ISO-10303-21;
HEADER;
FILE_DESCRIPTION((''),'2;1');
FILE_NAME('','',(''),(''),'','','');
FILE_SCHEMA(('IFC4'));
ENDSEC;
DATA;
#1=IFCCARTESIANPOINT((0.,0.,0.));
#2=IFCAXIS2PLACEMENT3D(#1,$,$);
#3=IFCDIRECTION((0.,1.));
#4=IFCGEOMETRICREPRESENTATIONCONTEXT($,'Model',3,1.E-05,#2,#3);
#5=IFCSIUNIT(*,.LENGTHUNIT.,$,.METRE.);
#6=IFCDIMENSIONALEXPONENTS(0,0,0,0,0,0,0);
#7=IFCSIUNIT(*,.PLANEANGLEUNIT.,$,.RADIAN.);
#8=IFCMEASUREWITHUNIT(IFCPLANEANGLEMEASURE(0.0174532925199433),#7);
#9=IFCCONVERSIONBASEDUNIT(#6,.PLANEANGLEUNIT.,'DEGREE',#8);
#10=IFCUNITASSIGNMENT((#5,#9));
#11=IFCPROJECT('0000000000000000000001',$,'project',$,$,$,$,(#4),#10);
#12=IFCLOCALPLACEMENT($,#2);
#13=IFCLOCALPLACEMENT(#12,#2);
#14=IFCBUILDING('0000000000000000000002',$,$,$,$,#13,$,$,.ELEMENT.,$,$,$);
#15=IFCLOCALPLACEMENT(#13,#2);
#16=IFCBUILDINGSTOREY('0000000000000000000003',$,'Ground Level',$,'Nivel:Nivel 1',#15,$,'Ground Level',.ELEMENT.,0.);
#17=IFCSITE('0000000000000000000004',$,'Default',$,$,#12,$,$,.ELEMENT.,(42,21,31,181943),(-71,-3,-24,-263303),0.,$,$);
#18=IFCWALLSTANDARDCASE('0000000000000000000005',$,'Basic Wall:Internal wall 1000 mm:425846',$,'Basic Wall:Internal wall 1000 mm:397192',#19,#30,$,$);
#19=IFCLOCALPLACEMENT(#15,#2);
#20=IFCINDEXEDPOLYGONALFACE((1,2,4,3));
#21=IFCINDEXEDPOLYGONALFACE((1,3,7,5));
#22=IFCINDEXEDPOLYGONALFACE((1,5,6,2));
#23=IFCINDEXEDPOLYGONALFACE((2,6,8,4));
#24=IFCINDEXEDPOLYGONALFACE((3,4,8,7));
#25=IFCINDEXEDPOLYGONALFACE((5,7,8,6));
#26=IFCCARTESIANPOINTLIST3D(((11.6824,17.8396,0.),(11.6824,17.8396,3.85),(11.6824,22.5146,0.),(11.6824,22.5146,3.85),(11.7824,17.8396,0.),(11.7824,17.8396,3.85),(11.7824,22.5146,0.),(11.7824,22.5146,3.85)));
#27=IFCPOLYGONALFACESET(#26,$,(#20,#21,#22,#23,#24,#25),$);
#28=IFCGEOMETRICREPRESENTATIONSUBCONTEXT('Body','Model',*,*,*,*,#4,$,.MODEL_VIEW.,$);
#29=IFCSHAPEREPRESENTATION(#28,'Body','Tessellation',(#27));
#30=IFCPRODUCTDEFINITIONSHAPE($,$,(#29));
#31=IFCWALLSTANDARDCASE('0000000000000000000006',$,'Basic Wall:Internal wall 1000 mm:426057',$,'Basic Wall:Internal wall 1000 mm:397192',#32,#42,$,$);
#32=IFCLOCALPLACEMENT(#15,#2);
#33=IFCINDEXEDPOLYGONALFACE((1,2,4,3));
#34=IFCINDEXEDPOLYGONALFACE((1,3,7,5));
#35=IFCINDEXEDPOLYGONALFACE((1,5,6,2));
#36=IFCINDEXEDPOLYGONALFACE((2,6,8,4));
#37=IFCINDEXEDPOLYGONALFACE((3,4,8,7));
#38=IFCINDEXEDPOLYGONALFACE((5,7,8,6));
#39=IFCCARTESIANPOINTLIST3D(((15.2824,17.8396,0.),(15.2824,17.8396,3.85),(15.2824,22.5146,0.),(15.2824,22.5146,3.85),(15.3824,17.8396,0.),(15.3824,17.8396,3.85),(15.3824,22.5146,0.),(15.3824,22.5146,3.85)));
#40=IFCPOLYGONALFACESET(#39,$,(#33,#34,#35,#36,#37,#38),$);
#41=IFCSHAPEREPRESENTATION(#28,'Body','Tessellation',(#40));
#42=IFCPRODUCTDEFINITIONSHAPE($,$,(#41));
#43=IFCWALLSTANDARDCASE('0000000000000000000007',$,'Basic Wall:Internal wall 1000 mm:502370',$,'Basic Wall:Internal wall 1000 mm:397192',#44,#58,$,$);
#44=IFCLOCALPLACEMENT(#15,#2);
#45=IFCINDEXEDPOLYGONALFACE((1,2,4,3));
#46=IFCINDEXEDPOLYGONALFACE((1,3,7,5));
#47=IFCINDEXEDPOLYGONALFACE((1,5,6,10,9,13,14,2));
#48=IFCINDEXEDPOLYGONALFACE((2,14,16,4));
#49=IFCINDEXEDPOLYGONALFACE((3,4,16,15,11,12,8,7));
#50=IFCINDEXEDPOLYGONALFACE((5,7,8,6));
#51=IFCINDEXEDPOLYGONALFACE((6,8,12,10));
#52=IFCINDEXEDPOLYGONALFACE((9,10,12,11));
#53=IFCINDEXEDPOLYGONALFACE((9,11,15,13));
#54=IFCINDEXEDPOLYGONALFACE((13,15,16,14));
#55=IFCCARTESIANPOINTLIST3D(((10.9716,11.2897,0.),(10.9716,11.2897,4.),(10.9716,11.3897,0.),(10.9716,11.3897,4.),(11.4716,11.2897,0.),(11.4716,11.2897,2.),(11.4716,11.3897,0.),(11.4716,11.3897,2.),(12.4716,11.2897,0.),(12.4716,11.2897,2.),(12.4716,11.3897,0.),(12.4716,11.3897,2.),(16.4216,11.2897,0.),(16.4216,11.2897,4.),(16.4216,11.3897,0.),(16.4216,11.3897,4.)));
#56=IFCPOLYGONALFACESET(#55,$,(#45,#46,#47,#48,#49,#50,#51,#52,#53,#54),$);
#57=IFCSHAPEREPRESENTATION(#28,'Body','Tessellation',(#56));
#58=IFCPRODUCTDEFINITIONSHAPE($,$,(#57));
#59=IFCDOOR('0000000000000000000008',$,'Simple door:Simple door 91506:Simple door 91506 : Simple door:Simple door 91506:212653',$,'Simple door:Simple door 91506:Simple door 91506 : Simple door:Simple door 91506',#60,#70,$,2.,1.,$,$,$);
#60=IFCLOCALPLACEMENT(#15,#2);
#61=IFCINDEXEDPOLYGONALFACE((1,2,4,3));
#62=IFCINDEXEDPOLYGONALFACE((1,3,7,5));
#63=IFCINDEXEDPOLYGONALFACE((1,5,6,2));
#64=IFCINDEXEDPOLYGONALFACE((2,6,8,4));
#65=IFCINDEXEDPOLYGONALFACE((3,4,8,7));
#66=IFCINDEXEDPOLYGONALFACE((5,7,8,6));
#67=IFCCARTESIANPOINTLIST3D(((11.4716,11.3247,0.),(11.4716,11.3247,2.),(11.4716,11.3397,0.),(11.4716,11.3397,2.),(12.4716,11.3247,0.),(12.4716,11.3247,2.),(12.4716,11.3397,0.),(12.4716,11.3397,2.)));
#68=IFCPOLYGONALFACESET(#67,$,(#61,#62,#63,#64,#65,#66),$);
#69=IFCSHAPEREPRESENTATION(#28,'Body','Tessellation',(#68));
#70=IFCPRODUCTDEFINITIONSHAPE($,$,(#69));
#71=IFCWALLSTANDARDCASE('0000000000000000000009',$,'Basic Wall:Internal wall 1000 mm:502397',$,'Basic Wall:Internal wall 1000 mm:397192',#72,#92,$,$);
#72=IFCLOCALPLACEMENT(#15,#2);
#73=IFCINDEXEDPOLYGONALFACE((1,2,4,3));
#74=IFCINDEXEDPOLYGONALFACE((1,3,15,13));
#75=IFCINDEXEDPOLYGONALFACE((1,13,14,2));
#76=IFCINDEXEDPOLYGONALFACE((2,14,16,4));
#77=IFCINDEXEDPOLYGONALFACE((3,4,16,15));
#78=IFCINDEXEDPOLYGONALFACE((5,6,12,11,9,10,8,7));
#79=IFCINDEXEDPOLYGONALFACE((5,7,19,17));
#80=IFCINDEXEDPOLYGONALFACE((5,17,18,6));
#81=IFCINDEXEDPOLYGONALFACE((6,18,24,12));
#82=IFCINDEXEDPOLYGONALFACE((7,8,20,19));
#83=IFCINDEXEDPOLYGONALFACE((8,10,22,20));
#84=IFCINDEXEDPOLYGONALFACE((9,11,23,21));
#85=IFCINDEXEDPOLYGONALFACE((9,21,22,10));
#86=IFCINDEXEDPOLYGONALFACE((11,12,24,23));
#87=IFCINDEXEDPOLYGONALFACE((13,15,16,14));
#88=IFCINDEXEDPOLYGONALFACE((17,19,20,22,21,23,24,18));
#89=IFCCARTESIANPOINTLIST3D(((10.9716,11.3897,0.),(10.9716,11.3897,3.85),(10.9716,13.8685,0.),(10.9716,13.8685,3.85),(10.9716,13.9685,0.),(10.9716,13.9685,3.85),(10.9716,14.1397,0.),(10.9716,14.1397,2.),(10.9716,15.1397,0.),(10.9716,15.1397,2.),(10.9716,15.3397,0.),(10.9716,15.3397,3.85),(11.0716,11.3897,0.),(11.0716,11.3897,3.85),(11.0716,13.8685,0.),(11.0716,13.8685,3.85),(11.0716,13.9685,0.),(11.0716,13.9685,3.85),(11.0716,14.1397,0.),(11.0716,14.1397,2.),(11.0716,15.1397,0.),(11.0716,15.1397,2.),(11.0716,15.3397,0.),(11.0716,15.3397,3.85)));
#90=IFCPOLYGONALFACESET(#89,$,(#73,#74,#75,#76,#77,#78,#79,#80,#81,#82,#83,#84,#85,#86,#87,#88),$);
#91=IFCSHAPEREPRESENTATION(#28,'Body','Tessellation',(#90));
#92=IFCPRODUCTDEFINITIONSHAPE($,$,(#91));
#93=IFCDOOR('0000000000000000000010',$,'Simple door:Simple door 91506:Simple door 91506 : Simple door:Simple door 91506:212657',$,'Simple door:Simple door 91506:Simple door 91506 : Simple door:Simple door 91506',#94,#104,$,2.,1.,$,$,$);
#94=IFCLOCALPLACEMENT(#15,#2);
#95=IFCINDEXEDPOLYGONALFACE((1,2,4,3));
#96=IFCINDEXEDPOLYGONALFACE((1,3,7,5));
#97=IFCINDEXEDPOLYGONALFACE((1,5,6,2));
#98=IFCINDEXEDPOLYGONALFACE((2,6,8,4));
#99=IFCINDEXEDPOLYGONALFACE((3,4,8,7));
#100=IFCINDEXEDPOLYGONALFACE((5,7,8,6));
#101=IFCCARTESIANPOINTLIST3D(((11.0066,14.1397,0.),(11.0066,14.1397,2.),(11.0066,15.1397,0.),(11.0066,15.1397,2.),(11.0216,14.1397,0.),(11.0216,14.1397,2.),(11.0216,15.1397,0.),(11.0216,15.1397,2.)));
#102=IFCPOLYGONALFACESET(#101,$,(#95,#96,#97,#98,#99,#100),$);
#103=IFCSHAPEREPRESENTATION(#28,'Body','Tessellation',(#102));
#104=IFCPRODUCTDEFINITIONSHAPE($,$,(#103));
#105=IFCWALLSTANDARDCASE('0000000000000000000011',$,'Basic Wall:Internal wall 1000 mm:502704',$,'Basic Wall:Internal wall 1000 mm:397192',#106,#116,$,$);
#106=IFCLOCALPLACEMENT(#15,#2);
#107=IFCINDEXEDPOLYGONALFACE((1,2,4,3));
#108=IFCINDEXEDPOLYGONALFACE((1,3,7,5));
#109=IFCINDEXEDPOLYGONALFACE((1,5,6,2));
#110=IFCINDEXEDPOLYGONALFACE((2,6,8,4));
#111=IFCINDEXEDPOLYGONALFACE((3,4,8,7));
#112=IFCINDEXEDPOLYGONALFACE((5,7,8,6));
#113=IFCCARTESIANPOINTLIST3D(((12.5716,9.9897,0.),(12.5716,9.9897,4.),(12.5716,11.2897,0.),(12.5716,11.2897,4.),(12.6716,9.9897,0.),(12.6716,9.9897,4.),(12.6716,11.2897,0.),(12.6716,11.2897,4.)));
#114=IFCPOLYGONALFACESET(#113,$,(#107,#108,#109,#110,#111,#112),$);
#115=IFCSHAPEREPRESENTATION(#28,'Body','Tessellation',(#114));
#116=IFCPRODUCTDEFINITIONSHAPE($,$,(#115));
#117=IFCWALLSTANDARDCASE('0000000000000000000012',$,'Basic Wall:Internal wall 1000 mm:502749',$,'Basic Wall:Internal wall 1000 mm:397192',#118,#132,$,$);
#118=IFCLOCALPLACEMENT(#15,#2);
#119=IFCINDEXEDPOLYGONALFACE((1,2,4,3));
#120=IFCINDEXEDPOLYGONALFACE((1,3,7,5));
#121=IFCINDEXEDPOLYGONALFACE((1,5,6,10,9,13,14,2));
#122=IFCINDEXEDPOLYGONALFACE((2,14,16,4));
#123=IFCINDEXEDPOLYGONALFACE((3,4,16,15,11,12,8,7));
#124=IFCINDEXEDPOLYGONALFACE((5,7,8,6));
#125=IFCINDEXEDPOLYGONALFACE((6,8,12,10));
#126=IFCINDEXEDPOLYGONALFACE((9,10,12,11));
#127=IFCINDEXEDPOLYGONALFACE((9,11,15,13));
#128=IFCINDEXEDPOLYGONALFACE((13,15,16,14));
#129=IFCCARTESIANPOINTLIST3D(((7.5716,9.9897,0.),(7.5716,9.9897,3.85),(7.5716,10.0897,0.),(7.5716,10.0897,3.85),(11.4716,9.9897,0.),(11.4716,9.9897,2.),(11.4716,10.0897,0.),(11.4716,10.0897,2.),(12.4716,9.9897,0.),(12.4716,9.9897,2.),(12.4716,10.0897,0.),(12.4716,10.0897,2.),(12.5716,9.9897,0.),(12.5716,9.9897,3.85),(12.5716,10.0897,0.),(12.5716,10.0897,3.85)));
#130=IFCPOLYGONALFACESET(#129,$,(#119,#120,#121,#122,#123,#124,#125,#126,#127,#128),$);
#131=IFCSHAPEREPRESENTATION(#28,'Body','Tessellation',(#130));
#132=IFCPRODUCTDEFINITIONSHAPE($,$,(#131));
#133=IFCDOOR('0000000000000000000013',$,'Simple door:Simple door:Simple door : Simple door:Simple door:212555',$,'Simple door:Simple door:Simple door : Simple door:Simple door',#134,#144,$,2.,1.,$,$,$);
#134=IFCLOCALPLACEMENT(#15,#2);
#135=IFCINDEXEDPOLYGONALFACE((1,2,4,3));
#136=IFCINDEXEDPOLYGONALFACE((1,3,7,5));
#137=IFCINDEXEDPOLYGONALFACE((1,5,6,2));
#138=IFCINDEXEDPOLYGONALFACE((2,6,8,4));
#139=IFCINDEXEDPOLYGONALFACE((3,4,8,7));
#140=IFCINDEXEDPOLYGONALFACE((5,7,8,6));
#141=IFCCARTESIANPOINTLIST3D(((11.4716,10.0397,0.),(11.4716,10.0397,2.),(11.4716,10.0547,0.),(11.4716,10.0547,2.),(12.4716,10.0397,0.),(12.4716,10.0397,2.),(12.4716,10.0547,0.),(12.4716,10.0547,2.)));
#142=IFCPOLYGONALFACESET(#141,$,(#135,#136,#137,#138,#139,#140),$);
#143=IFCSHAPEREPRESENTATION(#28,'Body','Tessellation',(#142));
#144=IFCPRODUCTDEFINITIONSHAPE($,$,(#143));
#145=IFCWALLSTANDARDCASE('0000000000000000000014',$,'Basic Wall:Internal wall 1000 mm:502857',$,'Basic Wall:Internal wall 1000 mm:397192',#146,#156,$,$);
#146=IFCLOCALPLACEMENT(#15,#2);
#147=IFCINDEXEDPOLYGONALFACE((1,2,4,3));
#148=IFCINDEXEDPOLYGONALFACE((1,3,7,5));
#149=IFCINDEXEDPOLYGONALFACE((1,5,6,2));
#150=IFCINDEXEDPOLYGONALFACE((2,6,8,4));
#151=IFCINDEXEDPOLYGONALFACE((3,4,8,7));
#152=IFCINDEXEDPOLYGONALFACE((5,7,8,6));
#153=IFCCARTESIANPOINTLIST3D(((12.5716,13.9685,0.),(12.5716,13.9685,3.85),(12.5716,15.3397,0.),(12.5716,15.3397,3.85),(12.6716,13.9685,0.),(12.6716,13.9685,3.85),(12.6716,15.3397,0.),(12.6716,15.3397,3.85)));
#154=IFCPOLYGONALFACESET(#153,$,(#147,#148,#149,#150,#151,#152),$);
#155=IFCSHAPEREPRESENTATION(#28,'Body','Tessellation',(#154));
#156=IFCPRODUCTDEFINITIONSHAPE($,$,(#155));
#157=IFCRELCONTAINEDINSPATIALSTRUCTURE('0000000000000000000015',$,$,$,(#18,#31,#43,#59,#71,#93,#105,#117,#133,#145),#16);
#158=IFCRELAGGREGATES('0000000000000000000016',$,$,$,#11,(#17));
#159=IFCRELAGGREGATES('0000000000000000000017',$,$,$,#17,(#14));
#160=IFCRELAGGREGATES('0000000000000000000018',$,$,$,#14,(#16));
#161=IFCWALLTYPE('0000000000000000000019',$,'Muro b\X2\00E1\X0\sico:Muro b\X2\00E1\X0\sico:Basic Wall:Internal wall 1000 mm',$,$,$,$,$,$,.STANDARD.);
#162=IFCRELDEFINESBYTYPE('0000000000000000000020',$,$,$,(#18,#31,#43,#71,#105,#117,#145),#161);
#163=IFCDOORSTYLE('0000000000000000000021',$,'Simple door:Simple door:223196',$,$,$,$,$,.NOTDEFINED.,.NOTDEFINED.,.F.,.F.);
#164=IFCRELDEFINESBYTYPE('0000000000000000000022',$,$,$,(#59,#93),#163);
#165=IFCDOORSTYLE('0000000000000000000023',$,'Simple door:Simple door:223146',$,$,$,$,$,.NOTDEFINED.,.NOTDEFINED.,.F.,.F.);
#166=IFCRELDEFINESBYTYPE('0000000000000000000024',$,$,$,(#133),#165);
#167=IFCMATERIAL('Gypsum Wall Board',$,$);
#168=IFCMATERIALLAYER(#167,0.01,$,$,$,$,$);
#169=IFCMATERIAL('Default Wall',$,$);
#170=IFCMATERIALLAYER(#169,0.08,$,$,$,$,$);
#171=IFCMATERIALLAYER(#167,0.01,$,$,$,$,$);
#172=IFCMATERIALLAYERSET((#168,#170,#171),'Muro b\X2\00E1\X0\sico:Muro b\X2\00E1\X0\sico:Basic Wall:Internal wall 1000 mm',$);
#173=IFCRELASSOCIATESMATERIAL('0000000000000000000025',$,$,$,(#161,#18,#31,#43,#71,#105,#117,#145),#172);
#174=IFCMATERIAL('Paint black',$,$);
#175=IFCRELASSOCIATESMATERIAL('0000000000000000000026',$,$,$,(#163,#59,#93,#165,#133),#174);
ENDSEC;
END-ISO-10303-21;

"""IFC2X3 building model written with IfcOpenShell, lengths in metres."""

from ifc_helpers import new_model, entity, si_unit, converted_unit, direction, frame, frame_2d, origin, origin_2d_with_axis, place, context, subcontext, project, spatial, rectangle, extrude, source, transform, mapped, material, layer, layer_set, layer_usage, type_object, type_shapes, element, fill, save


model = new_model("IFC2X3")

# Units and contexts
model_context = context("Model", 3, precision=1e-05, world=origin(), true_north=direction((0.0, 1.0)))
body_context = subcontext(model_context, "Body", "Model", "MODEL_VIEW")
ifc_project = project(units=[si_unit("LENGTHUNIT", "METRE"), converted_unit("PLANEANGLEUNIT", "DEGREE", entity("IfcPlaneAngleMeasure", 0.0174532925199433), si_unit("PLANEANGLEUNIT", "RADIAN"), dimensions=[0, 0, 0, 0, 0, 0, 0])], contexts=[model_context])

# Site, building, storey
site_placement = place(None, origin())
site = spatial("IfcSite", under=ifc_project, at=site_placement, Name="Default", CompositionType="ELEMENT", RefLatitude=(42, 21, 31, 181943), RefLongitude=(-71, -3, -24, -263303), RefElevation=0.0)
building_placement = place(site_placement, origin())
building = spatial("IfcBuilding", under=site, at=building_placement, CompositionType="ELEMENT")
storey_placement = place(building_placement, origin())
storey = spatial("IfcBuildingStorey", under=building, at=storey_placement, Name="Ground Level", ObjectType="Nivel:Nivel 1", LongName="Ground Level", CompositionType="ELEMENT", Elevation=0.0)

# Walls
ifc_material_1 = material(Name="Gypsum Wall Board")
ifc_layer_1 = layer(ifc_material_1, 0.01)
ifc_material_2 = material(Name="Default Wall")
ifc_layer_2 = layer(ifc_material_2, 0.08)
ifc_layer_3 = layer(ifc_material_1, 0.01)
ifc_layer_set = layer_set([ifc_layer_1, ifc_layer_2, ifc_layer_3], Name="Muro básico:Muro básico:Basic Wall:Internal wall 1000 mm")
ifc_layer_usage_1 = layer_usage(ifc_layer_set, "AXIS2", "NEGATIVE", 0.05)
wall_type = type_object("IfcWallType", Name="Muro básico:Muro básico:Basic Wall:Internal wall 1000 mm", PredefinedType="STANDARD", material=ifc_layer_set)
wall_1_placement = place(storey_placement, frame((11.7324, 22.5146, 0.0), z_axis=(0.0, 0.0, 1.0), x_axis=(0.0, -1.0, 0.0)))
element("IfcWallStandardCase", 1, at=wall_1_placement, inside=storey, type_object=wall_type, material=ifc_layer_usage_1, Name="Basic Wall:Internal wall 1000 mm:425846", ObjectType="Basic Wall:Internal wall 1000 mm:397192", context=body_context, shape_type="SweptSolid", body=[
    extrude(rectangle(XDim=4.675, YDim=0.1, at=frame_2d((2.3375, 0.0), x_axis=(-1.0, 0.0))), origin(), (0.0, 0.0, 1.0), 3.85),
])
ifc_layer_usage_2 = layer_usage(ifc_layer_set, "AXIS2", "NEGATIVE", 0.05)
wall_2_placement = place(storey_placement, frame((15.3324, 17.8396, 0.0), z_axis=(0.0, 0.0, 1.0), x_axis=(0.0, 1.0, 0.0)))
element("IfcWallStandardCase", 2, at=wall_2_placement, inside=storey, type_object=wall_type, material=ifc_layer_usage_2, Name="Basic Wall:Internal wall 1000 mm:426057", ObjectType="Basic Wall:Internal wall 1000 mm:397192", context=body_context, shape_type="SweptSolid", body=[
    extrude(rectangle(XDim=4.675, YDim=0.1, at=frame_2d((2.3375, 0.0), x_axis=(-1.0, 0.0))), origin(), (0.0, 0.0, 1.0), 3.85),
])

# Wall, opening, door
ifc_layer_usage_3 = layer_usage(ifc_layer_set, "AXIS2", "NEGATIVE", 0.05)
wall_3_placement = place(storey_placement, frame((16.4216, 11.3397, 0.0), z_axis=(0.0, 0.0, 1.0), x_axis=(-1.0, 0.0, 0.0)))
wall_3 = element("IfcWallStandardCase", 3, at=wall_3_placement, inside=storey, type_object=wall_type, material=ifc_layer_usage_3, Name="Basic Wall:Internal wall 1000 mm:502370", ObjectType="Basic Wall:Internal wall 1000 mm:397192", context=body_context, shape_type="SweptSolid", body=[
    extrude(rectangle(XDim=5.45, YDim=0.1, at=frame_2d((2.725, 0.0), x_axis=(1.0, 0.0))), origin(), (0.0, 0.0, 1.0), 4.0),
])
opening_1_placement = place(wall_3_placement, frame((16.4216, 11.3397, 0.0), z_axis=(0.0, 0.0, 1.0), x_axis=(-1.0, 0.0, 0.0)))
opening_1 = element("IfcOpeningElement", 4, at=opening_1_placement, cuts=wall_3, ObjectType="Opening", context=body_context, shape_type="SweptSolid", body=[
    extrude(rectangle(XDim=2.0, YDim=1.0, at=frame_2d((0.0, 0.0), x_axis=(0.0, 1.0))), frame((11.9716, 11.3917, 1.0), z_axis=(0.0, -1.0, 0.0), x_axis=(1.0, 0.0, 0.0)), (0.0, 0.0, 1.0), 0.104),
])
ifc_material_3 = material(Name="Paint black")
door_style_1 = type_object("IfcDoorStyle", Name="Simple door:Simple door:223196", ConstructionType="NOTDEFINED", OperationType="NOTDEFINED", ParameterTakesPrecedence=False, Sizeable=False, material=ifc_material_3)
shared_shape_1 = source(origin(), body_context, "Body", "SweptSolid", [
    extrude(rectangle(XDim=1.0, YDim=0.015, at=origin_2d_with_axis()), frame((0.5, 0.0445, 0.0)), (0.0, 0.0, 1.0), 2.0),
])
type_shapes(door_style_1, [shared_shape_1])
door_1_placement = place(opening_1_placement, frame((11.4716, 11.2877, 0.0)))
door_1 = element("IfcDoor", 5, at=door_1_placement, inside=storey, type_object=door_style_1, material=ifc_material_3, Name="Simple door:Simple door 91506:Simple door 91506 : Simple door:Simple door 91506:212653", ObjectType="Simple door:Simple door 91506:Simple door 91506 : Simple door:Simple door 91506", OverallHeight=2.0, OverallWidth=1.0, context=body_context, shape_type="MappedRepresentation", body=[
    mapped(shared_shape_1, transform((0.0, 0.0, 0.0), scale=1.0)),
])
fill(opening_1, door_1)

# Wall, openings, door
ifc_layer_usage_4 = layer_usage(ifc_layer_set, "AXIS2", "NEGATIVE", 0.05)
wall_4_placement = place(storey_placement, frame((11.0216, 11.3897, 0.0), z_axis=(0.0, 0.0, 1.0), x_axis=(0.0, 1.0, 0.0)))
wall_4 = element("IfcWallStandardCase", 6, at=wall_4_placement, inside=storey, type_object=wall_type, material=ifc_layer_usage_4, Name="Basic Wall:Internal wall 1000 mm:502397", ObjectType="Basic Wall:Internal wall 1000 mm:397192", context=body_context, shape_type="SweptSolid", body=[
    extrude(rectangle(XDim=3.95, YDim=0.1, at=frame_2d((1.975, 0.0), x_axis=(-1.0, 0.0))), origin(), (0.0, 0.0, 1.0), 3.85),
])
opening_2_placement = place(storey_placement, frame((11.0216, 11.3897, 0.0), z_axis=(0.0, 0.0, 1.0), x_axis=(0.0, 1.0, 0.0)))
element("IfcOpeningElement", 7, at=opening_2_placement, cuts=wall_4, ObjectType="Opening", context=body_context, shape_type="SweptSolid", body=[
    extrude(rectangle(XDim=3.85, YDim=0.1, at=origin_2d_with_axis()), frame((2.4788, 0.0, 1.925), z_axis=(1.0, 0.0, 0.0), x_axis=(0.0, 0.0, -1.0)), (0.0, 0.0, 1.0), 0.1),
])
opening_3_placement = place(wall_4_placement, frame((-11.3897, 11.0216, 0.0), z_axis=(0.0, 0.0, 1.0), x_axis=(0.0, -1.0, 0.0)))
opening_3 = element("IfcOpeningElement", 8, at=opening_3_placement, cuts=wall_4, ObjectType="Opening", context=body_context, shape_type="SweptSolid", body=[
    extrude(rectangle(XDim=2.0, YDim=1.0, at=frame_2d((0.0, 0.0), x_axis=(0.0, 1.0))), frame((11.0736, 14.6397, 1.0), z_axis=(-1.0, 0.0, 0.0), x_axis=(0.0, -1.0, 0.0)), (0.0, 0.0, 1.0), 0.104),
])
door_2_placement = place(opening_3_placement, frame((10.9696, 15.1397, 0.0), z_axis=(0.0, 0.0, 1.0), x_axis=(0.0, -1.0, 0.0)))
door_2 = element("IfcDoor", 9, at=door_2_placement, inside=storey, type_object=door_style_1, material=ifc_material_3, Name="Simple door:Simple door 91506:Simple door 91506 : Simple door:Simple door 91506:212657", ObjectType="Simple door:Simple door 91506:Simple door 91506 : Simple door:Simple door 91506", OverallHeight=2.0, OverallWidth=1.0, context=body_context, shape_type="MappedRepresentation", body=[
    mapped(shared_shape_1, transform((0.0, 0.0, 0.0), scale=1.0)),
])
fill(opening_3, door_2)

# Wall
ifc_layer_usage_5 = layer_usage(ifc_layer_set, "AXIS2", "NEGATIVE", 0.05)
wall_5_placement = place(storey_placement, frame((12.6216, 11.2897, 0.0), z_axis=(0.0, 0.0, 1.0), x_axis=(0.0, -1.0, 0.0)))
element("IfcWallStandardCase", 10, at=wall_5_placement, inside=storey, type_object=wall_type, material=ifc_layer_usage_5, Name="Basic Wall:Internal wall 1000 mm:502704", ObjectType="Basic Wall:Internal wall 1000 mm:397192", context=body_context, shape_type="SweptSolid", body=[
    extrude(rectangle(XDim=1.3, YDim=0.1, at=frame_2d((0.65, 0.0), x_axis=(-1.0, 0.0))), origin(), (0.0, 0.0, 1.0), 4.0),
])

# Wall, opening, door
ifc_layer_usage_6 = layer_usage(ifc_layer_set, "AXIS2", "NEGATIVE", 0.05)
wall_6_placement = place(storey_placement, frame((12.5716, 10.0397, 0.0), z_axis=(0.0, 0.0, 1.0), x_axis=(-1.0, 0.0, 0.0)))
wall_6 = element("IfcWallStandardCase", 11, at=wall_6_placement, inside=storey, type_object=wall_type, material=ifc_layer_usage_6, Name="Basic Wall:Internal wall 1000 mm:502749", ObjectType="Basic Wall:Internal wall 1000 mm:397192", context=body_context, shape_type="SweptSolid", body=[
    extrude(rectangle(XDim=5.0, YDim=0.1, at=frame_2d((2.5, 0.0), x_axis=(1.0, 0.0))), origin(), (0.0, 0.0, 1.0), 3.85),
])
opening_4_placement = place(wall_6_placement, frame((12.5716, 10.0397, 0.0), z_axis=(0.0, 0.0, 1.0), x_axis=(-1.0, 0.0, 0.0)))
opening_4 = element("IfcOpeningElement", 12, at=opening_4_placement, cuts=wall_6, ObjectType="Opening", context=body_context, shape_type="SweptSolid", body=[
    extrude(rectangle(XDim=2.0, YDim=1.0, at=frame_2d((0.0, 0.0), x_axis=(0.0, 1.0))), frame((11.9716, 10.0917, 1.0), z_axis=(0.0, -1.0, 0.0), x_axis=(1.0, 0.0, 0.0)), (0.0, 0.0, 1.0), 0.104),
])
door_style_2 = type_object("IfcDoorStyle", Name="Simple door:Simple door:223146", ConstructionType="NOTDEFINED", OperationType="NOTDEFINED", ParameterTakesPrecedence=False, Sizeable=False, material=ifc_material_3)
shared_shape_2 = source(origin(), body_context, "Body", "SweptSolid", [
    extrude(rectangle(XDim=1.0, YDim=0.015, at=origin_2d_with_axis()), frame((0.5, -0.0595, 0.0)), (0.0, 0.0, 1.0), 2.0),
])
type_shapes(door_style_2, [shared_shape_2])
door_3_placement = place(opening_4_placement, frame((12.4716, 9.9877, 0.0), z_axis=(0.0, 0.0, 1.0), x_axis=(-1.0, 0.0, 0.0)))
door_3 = element("IfcDoor", 13, at=door_3_placement, inside=storey, type_object=door_style_2, material=ifc_material_3, Name="Simple door:Simple door:Simple door : Simple door:Simple door:212555", ObjectType="Simple door:Simple door:Simple door : Simple door:Simple door", OverallHeight=2.0, OverallWidth=1.0, context=body_context, shape_type="MappedRepresentation", body=[
    mapped(shared_shape_2, transform((0.0, 0.0, 0.0), scale=1.0)),
])
fill(opening_4, door_3)

# Wall
ifc_layer_usage_7 = layer_usage(ifc_layer_set, "AXIS2", "NEGATIVE", 0.05)
wall_7_placement = place(storey_placement, frame((12.6216, 15.3397, 0.0), z_axis=(0.0, 0.0, 1.0), x_axis=(0.0, -1.0, 0.0)))
element("IfcWallStandardCase", 14, at=wall_7_placement, inside=storey, type_object=wall_type, material=ifc_layer_usage_7, Name="Basic Wall:Internal wall 1000 mm:502857", ObjectType="Basic Wall:Internal wall 1000 mm:397192", context=body_context, shape_type="SweptSolid", body=[
    extrude(rectangle(XDim=1.3712, YDim=0.1, at=frame_2d((0.6856, 0.0), x_axis=(-1.0, 0.0))), origin(), (0.0, 0.0, 1.0), 3.85),
])

save(model, "model.ifc")
